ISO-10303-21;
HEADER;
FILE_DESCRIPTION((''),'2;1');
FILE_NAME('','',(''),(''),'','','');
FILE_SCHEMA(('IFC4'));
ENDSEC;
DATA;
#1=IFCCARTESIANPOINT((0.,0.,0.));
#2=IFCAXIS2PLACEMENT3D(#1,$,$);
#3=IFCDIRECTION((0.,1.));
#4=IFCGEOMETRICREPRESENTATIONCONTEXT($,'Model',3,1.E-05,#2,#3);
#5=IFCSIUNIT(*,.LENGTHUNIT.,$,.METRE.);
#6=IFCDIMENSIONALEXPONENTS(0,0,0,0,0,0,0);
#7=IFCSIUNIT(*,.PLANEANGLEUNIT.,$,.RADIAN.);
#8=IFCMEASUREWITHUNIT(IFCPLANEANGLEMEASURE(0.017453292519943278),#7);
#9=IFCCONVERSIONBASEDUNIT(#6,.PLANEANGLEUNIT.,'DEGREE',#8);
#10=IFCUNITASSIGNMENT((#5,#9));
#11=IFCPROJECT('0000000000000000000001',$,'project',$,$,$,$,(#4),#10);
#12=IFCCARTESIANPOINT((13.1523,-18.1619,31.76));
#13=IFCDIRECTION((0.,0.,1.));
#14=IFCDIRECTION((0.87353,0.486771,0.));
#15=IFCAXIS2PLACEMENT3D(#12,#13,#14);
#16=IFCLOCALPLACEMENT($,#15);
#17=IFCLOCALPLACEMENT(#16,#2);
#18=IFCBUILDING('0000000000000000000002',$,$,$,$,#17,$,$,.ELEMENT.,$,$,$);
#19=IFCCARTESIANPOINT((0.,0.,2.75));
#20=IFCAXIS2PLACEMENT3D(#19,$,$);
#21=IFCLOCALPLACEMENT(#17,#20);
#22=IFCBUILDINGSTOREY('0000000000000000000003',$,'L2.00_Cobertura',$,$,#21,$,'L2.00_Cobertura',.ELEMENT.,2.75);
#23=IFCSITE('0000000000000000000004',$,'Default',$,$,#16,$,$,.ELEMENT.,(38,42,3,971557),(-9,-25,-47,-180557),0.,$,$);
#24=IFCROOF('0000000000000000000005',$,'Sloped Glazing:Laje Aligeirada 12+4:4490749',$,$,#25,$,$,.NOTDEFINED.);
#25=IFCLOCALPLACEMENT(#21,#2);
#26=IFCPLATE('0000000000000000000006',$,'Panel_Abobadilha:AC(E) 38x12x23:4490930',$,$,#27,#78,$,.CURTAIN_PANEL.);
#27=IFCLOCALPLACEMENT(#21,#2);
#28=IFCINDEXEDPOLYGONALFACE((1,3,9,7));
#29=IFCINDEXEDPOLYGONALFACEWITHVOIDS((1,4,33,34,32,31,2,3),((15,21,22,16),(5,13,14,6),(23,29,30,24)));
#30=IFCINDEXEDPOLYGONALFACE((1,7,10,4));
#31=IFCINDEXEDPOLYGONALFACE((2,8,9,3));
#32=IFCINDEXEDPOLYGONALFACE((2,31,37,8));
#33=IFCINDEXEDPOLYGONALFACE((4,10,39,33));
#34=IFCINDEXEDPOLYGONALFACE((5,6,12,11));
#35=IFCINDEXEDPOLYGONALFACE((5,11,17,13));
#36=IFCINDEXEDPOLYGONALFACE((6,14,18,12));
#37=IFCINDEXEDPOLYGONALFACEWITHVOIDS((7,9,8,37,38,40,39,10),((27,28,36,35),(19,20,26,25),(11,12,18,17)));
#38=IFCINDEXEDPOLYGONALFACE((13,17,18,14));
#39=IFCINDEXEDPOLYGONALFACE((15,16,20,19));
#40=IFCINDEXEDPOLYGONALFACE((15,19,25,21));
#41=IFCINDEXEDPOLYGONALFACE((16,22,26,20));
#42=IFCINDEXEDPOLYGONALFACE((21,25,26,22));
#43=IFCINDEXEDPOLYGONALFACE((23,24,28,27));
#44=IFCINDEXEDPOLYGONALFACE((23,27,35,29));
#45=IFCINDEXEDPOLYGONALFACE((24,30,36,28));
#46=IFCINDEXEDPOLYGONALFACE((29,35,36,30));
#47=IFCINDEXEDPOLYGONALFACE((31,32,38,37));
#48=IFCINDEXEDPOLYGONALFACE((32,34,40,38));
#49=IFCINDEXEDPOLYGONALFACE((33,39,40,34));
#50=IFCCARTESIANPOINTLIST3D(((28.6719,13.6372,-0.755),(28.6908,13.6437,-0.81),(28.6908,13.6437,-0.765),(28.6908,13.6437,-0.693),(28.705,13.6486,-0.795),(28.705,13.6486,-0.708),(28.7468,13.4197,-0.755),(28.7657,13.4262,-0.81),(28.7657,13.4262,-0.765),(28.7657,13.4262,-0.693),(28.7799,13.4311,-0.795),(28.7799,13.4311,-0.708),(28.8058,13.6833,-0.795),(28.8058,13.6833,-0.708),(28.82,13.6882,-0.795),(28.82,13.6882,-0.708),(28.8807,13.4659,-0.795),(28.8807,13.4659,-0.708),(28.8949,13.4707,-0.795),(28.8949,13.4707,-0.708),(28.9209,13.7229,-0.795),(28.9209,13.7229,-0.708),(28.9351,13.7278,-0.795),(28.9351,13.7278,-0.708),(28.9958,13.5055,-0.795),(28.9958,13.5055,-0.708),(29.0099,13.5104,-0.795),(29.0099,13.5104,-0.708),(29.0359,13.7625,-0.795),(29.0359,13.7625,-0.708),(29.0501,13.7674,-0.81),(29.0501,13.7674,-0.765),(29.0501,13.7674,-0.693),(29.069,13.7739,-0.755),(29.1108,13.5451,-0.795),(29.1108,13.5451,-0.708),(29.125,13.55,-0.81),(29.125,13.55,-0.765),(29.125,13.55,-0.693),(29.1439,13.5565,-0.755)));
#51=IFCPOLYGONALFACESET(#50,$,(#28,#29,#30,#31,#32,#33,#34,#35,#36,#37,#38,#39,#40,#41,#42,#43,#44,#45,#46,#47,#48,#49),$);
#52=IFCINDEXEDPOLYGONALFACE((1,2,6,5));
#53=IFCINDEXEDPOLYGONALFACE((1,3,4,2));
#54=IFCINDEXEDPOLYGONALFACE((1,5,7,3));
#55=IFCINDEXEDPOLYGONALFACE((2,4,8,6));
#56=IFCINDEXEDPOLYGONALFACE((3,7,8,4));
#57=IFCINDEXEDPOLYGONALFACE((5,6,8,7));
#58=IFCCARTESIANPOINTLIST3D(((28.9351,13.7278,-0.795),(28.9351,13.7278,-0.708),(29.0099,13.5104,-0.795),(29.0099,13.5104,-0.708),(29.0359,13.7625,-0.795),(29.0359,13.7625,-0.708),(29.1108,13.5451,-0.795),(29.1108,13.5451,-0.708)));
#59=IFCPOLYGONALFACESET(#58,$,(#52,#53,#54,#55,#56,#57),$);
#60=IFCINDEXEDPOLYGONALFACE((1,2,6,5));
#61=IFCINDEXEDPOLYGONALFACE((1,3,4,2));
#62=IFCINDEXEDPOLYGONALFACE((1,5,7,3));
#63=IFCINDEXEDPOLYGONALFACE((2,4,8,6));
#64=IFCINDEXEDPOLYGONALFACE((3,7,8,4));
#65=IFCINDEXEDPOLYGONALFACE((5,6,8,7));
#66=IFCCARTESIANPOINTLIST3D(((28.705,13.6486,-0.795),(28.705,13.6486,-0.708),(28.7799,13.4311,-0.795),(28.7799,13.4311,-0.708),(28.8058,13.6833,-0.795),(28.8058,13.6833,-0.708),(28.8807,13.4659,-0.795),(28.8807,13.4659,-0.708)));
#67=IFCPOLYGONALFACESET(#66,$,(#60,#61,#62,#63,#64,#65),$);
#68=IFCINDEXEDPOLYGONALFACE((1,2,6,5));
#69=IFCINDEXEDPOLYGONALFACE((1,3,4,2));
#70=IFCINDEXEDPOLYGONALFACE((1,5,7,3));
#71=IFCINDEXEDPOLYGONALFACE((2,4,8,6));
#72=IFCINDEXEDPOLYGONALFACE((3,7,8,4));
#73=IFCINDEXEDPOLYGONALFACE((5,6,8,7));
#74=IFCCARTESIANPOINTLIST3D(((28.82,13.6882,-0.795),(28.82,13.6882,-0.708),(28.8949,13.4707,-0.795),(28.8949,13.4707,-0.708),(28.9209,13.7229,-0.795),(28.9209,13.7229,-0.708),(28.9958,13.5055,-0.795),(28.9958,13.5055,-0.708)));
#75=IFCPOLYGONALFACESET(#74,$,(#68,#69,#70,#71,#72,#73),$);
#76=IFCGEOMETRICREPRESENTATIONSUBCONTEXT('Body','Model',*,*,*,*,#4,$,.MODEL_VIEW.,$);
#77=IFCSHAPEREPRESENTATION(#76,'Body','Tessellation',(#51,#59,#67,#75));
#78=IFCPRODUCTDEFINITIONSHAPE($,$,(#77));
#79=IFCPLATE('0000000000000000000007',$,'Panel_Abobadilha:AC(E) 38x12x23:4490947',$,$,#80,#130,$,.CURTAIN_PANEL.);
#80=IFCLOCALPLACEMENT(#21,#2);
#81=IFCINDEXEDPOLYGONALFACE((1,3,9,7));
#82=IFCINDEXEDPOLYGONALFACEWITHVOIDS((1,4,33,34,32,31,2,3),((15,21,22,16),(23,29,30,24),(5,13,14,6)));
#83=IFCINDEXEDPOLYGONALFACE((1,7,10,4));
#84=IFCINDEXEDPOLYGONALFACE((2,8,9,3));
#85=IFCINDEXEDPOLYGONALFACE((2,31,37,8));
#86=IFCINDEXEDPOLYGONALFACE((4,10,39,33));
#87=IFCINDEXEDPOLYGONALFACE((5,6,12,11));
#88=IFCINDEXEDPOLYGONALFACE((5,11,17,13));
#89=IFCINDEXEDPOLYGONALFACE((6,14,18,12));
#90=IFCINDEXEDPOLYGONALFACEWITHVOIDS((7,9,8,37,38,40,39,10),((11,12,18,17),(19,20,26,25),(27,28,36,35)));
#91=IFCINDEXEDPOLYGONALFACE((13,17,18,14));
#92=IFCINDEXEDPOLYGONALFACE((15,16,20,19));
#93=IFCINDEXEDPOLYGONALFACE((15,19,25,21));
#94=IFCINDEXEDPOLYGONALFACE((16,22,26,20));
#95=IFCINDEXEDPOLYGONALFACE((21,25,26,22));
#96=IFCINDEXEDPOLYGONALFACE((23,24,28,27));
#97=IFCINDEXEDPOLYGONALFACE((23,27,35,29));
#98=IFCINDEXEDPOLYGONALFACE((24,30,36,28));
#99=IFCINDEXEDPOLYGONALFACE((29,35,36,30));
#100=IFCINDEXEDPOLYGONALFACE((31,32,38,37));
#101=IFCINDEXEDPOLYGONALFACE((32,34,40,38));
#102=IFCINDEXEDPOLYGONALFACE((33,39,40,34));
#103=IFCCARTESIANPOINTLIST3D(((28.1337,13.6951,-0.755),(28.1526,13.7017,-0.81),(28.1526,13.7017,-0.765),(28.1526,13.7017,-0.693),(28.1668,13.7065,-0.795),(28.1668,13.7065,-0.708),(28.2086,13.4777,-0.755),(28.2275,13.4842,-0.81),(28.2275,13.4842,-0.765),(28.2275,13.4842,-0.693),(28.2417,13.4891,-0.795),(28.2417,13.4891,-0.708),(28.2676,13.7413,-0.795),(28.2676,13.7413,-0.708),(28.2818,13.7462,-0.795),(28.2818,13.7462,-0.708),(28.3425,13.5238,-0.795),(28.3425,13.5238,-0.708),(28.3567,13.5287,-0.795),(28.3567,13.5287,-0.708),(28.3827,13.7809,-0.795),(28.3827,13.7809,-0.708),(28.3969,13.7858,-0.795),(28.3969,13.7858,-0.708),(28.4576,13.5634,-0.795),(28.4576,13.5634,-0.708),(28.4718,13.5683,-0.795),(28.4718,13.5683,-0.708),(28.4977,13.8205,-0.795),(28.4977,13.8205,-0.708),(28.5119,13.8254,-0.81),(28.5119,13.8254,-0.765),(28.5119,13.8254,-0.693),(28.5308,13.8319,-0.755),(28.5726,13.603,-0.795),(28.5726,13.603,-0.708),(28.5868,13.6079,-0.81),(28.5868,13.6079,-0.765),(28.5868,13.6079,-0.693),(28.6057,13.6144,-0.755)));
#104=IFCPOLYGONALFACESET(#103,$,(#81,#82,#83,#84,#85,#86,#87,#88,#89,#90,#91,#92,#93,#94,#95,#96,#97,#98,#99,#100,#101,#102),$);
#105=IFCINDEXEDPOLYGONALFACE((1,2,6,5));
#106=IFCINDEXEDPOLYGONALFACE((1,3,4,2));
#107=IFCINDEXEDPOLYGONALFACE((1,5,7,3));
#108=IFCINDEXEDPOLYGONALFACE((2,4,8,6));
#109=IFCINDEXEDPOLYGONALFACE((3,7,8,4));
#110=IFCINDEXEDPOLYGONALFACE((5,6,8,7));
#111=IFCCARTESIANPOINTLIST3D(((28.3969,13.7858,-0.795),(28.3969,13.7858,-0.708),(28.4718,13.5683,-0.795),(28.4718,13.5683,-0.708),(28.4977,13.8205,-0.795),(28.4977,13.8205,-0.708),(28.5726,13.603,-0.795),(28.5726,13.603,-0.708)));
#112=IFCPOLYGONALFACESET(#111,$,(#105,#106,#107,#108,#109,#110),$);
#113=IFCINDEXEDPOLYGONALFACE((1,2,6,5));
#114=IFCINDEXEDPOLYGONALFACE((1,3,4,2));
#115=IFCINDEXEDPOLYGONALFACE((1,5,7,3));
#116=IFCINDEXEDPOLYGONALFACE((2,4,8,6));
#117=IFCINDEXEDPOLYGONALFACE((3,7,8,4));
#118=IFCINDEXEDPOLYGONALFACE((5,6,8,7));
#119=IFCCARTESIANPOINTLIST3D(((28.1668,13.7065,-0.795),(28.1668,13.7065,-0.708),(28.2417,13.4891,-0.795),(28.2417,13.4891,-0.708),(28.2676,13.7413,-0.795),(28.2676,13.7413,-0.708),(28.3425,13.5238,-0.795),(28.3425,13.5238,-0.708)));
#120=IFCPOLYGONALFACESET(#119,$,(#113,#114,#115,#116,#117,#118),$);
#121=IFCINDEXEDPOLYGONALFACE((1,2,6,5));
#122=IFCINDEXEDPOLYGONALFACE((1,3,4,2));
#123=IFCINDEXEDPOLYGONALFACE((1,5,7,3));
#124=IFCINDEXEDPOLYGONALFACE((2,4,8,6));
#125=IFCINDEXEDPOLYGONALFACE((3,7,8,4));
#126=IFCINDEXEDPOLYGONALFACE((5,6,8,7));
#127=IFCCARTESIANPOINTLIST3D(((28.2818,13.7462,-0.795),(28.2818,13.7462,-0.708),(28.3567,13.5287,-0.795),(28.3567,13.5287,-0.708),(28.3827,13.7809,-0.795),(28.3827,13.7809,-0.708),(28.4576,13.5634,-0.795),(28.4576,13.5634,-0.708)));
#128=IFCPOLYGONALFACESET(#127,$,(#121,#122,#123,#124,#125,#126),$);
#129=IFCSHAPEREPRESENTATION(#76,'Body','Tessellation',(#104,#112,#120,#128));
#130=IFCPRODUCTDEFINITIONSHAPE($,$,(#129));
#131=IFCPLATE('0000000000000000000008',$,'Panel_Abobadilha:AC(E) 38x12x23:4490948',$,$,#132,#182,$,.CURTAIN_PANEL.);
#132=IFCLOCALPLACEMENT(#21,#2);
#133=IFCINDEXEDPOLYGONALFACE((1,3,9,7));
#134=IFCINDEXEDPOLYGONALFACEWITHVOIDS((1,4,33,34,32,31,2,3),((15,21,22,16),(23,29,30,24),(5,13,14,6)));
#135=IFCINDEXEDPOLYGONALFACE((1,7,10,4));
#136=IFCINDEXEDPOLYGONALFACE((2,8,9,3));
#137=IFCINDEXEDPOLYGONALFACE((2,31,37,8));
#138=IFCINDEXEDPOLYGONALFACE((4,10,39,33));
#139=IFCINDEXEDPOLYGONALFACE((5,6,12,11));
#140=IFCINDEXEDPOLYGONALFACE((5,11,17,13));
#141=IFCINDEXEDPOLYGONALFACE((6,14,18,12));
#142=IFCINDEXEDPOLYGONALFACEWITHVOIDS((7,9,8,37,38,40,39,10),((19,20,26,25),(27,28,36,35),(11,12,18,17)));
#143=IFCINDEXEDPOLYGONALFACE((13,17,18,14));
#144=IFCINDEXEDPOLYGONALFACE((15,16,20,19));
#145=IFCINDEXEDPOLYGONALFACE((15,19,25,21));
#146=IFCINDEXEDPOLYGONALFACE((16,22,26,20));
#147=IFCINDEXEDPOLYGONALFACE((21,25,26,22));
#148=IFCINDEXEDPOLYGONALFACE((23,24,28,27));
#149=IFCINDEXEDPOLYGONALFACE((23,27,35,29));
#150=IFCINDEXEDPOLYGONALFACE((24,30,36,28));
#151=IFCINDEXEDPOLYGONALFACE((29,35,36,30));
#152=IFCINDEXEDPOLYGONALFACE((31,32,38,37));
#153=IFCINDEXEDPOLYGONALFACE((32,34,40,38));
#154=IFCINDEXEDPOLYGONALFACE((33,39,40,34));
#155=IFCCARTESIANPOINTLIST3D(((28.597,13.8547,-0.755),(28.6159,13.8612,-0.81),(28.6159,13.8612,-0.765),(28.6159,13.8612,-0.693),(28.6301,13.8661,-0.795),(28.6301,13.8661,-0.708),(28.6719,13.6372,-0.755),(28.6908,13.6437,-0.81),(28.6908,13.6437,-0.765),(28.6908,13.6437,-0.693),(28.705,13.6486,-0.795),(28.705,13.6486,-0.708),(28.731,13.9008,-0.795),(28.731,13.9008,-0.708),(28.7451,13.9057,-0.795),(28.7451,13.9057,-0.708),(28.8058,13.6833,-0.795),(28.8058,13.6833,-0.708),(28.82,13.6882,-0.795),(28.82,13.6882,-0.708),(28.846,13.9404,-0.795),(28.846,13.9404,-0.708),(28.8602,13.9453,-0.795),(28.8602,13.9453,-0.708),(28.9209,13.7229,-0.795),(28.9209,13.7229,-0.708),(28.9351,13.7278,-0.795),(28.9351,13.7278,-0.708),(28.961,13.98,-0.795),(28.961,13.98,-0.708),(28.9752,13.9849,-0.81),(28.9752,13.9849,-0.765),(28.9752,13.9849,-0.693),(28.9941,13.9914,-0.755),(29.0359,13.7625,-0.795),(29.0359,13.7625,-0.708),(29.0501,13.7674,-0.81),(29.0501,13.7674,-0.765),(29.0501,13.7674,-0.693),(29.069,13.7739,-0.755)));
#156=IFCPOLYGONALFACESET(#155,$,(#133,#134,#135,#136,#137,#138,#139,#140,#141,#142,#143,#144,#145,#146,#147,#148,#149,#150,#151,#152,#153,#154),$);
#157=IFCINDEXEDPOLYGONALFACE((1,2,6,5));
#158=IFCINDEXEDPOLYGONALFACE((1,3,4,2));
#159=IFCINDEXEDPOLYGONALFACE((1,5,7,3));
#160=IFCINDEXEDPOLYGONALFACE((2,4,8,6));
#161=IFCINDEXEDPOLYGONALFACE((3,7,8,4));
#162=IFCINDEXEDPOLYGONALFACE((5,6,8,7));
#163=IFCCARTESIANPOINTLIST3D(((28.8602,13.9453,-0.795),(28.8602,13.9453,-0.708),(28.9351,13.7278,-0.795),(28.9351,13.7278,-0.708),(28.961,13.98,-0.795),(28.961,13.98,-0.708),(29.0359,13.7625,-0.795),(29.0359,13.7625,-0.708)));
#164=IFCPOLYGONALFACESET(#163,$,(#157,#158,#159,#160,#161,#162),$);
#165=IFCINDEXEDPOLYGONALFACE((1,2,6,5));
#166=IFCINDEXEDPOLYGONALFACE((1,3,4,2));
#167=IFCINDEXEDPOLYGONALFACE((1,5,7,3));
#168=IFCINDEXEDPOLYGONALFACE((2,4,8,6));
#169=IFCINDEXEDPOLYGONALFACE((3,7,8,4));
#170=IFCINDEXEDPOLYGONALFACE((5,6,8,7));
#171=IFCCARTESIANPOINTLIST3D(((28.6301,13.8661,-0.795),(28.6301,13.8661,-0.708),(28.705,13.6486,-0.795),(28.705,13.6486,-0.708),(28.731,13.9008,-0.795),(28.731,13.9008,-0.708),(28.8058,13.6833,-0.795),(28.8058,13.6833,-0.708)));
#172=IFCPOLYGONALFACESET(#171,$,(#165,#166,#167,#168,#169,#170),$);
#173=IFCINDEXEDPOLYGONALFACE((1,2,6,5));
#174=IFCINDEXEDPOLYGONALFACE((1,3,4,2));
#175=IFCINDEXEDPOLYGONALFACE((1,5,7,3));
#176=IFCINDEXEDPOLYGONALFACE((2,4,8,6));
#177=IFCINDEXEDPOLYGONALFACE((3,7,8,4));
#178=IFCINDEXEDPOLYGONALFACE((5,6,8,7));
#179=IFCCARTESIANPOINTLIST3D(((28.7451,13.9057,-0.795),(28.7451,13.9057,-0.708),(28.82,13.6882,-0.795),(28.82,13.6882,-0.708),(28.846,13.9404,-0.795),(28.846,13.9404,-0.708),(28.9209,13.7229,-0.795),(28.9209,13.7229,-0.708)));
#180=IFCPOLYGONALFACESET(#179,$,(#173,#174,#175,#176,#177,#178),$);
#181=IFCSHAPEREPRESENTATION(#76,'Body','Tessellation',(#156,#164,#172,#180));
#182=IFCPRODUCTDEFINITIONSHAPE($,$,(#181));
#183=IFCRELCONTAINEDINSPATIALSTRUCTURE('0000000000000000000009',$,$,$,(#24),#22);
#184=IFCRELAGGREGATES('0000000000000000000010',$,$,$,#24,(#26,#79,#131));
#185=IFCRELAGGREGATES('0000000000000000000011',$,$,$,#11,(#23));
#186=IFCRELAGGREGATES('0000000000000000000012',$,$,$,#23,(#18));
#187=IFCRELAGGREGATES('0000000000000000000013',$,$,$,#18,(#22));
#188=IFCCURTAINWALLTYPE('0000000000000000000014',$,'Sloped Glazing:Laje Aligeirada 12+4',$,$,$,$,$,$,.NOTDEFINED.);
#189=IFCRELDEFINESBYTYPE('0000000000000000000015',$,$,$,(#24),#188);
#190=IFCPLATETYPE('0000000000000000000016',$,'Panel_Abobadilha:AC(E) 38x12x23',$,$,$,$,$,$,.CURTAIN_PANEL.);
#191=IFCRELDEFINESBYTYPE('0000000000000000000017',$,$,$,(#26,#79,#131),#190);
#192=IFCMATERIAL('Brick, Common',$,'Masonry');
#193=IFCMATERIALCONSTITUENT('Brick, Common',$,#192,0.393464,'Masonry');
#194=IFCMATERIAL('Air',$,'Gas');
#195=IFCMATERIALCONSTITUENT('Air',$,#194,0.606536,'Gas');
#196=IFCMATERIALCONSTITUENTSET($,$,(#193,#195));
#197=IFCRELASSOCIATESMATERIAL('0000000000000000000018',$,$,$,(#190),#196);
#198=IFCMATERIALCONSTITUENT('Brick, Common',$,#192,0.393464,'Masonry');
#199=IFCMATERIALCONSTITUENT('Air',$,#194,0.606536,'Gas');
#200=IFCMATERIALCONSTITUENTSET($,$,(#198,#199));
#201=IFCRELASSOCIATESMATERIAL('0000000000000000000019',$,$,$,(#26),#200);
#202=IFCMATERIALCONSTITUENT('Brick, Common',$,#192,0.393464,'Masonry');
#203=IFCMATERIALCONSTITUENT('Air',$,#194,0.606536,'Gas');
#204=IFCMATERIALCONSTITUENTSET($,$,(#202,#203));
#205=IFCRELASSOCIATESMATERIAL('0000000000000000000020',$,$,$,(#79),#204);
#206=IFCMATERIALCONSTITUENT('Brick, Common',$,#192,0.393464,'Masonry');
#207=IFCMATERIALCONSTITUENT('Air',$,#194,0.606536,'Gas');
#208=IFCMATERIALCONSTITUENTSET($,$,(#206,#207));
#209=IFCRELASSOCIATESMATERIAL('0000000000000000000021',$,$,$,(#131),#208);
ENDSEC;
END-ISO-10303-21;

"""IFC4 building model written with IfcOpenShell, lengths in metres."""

from ifc_helpers import new_model, entity, si_unit, converted_unit, direction, frame, origin, place, context, subcontext, project, spatial, indexed_curve, outline, extrude, source, transform, mapped, material, constituent, constituent_set, type_object, type_shapes, element, aggregate, save


model = new_model("IFC4")

# Units and contexts
model_context = context("Model", 3, precision=1e-05, world=origin(), true_north=direction((0.0, 1.0)))
body_context = subcontext(model_context, "Body", "Model", "MODEL_VIEW")
ifc_project = project(units=[si_unit("LENGTHUNIT", "METRE"), converted_unit("PLANEANGLEUNIT", "DEGREE", entity("IfcPlaneAngleMeasure", 0.017453292519943278), si_unit("PLANEANGLEUNIT", "RADIAN"), dimensions=[0, 0, 0, 0, 0, 0, 0])], contexts=[model_context])

# Site, building, storey
site_placement = place(None, frame((13.1523, -18.1619, 31.76), z_axis=(0.0, 0.0, 1.0), x_axis=(0.87353, 0.486771, 0.0)))
site = spatial("IfcSite", under=ifc_project, at=site_placement, Name="Default", CompositionType="ELEMENT", RefLatitude=(38, 42, 3, 971557), RefLongitude=(-9, -25, -47, -180557), RefElevation=0.0)
building_placement = place(site_placement, origin())
building = spatial("IfcBuilding", under=site, at=building_placement, CompositionType="ELEMENT")
storey_placement = place(building_placement, frame((0.0, 0.0, 2.75)))
storey = spatial("IfcBuildingStorey", under=building, at=storey_placement, Name="L2.00_Cobertura", LongName="L2.00_Cobertura", CompositionType="ELEMENT", Elevation=2.75)

# Roof, plates
curtain_wall_type = type_object("IfcCurtainWallType", Name="Sloped Glazing:Laje Aligeirada 12+4", PredefinedType="NOTDEFINED")
roof_placement = place(storey_placement, frame((0.0, 0.0, -2.75)))
roof = element("IfcRoof", 1, at=roof_placement, inside=storey, type_object=curtain_wall_type, Name="Sloped Glazing:Laje Aligeirada 12+4:4490749", PredefinedType="NOTDEFINED")
ifc_material_1 = material(Name="Brick, Common", Category="Masonry")
ifc_material_2 = material(Name="Air", Category="Gas")
ifc_constituent_1 = constituent(ifc_material_1, Name="Brick, Common", Category="Masonry", fraction=0.393464)
ifc_constituent_2 = constituent(ifc_material_2, Name="Air", Category="Gas", fraction=0.606536)
ifc_constituent_set_1 = constituent_set(constituents=[ifc_constituent_1, ifc_constituent_2])
plate_type_1 = type_object("IfcPlateType", Name="Panel_Abobadilha:AC(E) 38x12x23", PredefinedType="CURTAIN_PANEL", material=ifc_constituent_set_1)
shared_shape_1 = source(origin(), body_context, "Body", "SweptSolid", [
    extrude(outline(indexed_curve([(-0.19, -0.0543), (0.19, -0.0543), (0.19, -0.0093), (0.21, 0.0007), (0.19, 0.0628), (-0.19, 0.0628), (-0.21, 0.0007), (-0.19, -0.0093), (-0.19, -0.0543)], self_intersect=False), holes=[indexed_curve([(-0.0683, 0.0477), (-0.0683, -0.0393), (-0.175, -0.0393), (-0.175, 0.0477), (-0.0683, 0.0477)], self_intersect=False), indexed_curve([(0.0533, 0.0477), (0.0533, -0.0393), (-0.0533, -0.0393), (-0.0533, 0.0477), (0.0533, 0.0477)], self_intersect=False), indexed_curve([(0.175, 0.0477), (0.175, -0.0393), (0.0683, -0.0393), (0.0683, 0.0477), (0.175, 0.0477)], self_intersect=False)]), frame((0.0, 0.0543, 0.0)), (0.0, 0.0, 1.0), 0.23),
    extrude(outline(indexed_curve([(-0.0533, -0.0435), (0.0533, -0.0435), (0.0533, 0.0435), (-0.0533, 0.0435), (-0.0533, -0.0435)], self_intersect=False)), frame((0.1217, 0.0585, 0.0), z_axis=(0.0, 0.0, 1.0), x_axis=(-1.0, 0.0, 0.0)), (0.0, 0.0, 1.0), 0.23),
    extrude(outline(indexed_curve([(-0.0533, -0.0435), (0.0533, -0.0435), (0.0533, 0.0435), (-0.0533, 0.0435), (-0.0533, -0.0435)], self_intersect=False)), frame((-0.1217, 0.0585, 0.0), z_axis=(0.0, 0.0, 1.0), x_axis=(-1.0, 0.0, 0.0)), (0.0, 0.0, 1.0), 0.23),
    extrude(outline(indexed_curve([(-0.0533, -0.0435), (0.0533, -0.0435), (0.0533, 0.0435), (-0.0533, 0.0435), (-0.0533, -0.0435)], self_intersect=False)), frame((0.0, 0.0585, 0.0), z_axis=(0.0, 0.0, 1.0), x_axis=(-1.0, 0.0, 0.0)), (0.0, 0.0, 1.0), 0.23),
])
type_shapes(plate_type_1, [shared_shape_1])
ifc_constituent_3 = constituent(ifc_material_1, Name="Brick, Common", Category="Masonry", fraction=0.393464)
ifc_constituent_4 = constituent(ifc_material_2, Name="Air", Category="Gas", fraction=0.606536)
ifc_constituent_set_2 = constituent_set(constituents=[ifc_constituent_3, ifc_constituent_4])
plate_1_placement = place(roof_placement, frame((28.8704, 13.7056, 1.94), z_axis=(0.325568, -0.945519, 0.0), x_axis=(0.945519, 0.325568, 0.0)))
plate_1 = element("IfcPlate", 2, at=plate_1_placement, type_object=plate_type_1, material=ifc_constituent_set_2, Name="Panel_Abobadilha:AC(E) 38x12x23:4490930", PredefinedType="CURTAIN_PANEL", context=body_context, shape_type="MappedRepresentation", body=[
    mapped(shared_shape_1, transform((0.0, 0.0, 0.0), scale=1.0)),
])
ifc_constituent_5 = constituent(ifc_material_1, Name="Brick, Common", Category="Masonry", fraction=0.393464)
ifc_constituent_6 = constituent(ifc_material_2, Name="Air", Category="Gas", fraction=0.606536)
ifc_constituent_set_3 = constituent_set(constituents=[ifc_constituent_5, ifc_constituent_6])
plate_2_placement = place(roof_placement, frame((28.3323, 13.7635, 1.94), z_axis=(0.325568, -0.945519, 0.0), x_axis=(0.945519, 0.325568, 0.0)))
plate_2 = element("IfcPlate", 3, at=plate_2_placement, type_object=plate_type_1, material=ifc_constituent_set_3, Name="Panel_Abobadilha:AC(E) 38x12x23:4490947", PredefinedType="CURTAIN_PANEL", context=body_context, shape_type="MappedRepresentation", body=[
    mapped(shared_shape_1, transform((0.0, 0.0, 0.0), scale=1.0)),
])
ifc_constituent_7 = constituent(ifc_material_1, Name="Brick, Common", Category="Masonry", fraction=0.393464)
ifc_constituent_8 = constituent(ifc_material_2, Name="Air", Category="Gas", fraction=0.606536)
ifc_constituent_set_4 = constituent_set(constituents=[ifc_constituent_7, ifc_constituent_8])
plate_3_placement = place(roof_placement, frame((28.7956, 13.923, 1.94), z_axis=(0.325568, -0.945519, 0.0), x_axis=(0.945519, 0.325568, 0.0)))
plate_3 = element("IfcPlate", 4, at=plate_3_placement, type_object=plate_type_1, material=ifc_constituent_set_4, Name="Panel_Abobadilha:AC(E) 38x12x23:4490948", PredefinedType="CURTAIN_PANEL", context=body_context, shape_type="MappedRepresentation", body=[
    mapped(shared_shape_1, transform((0.0, 0.0, 0.0), scale=1.0)),
])
aggregate(roof, [plate_1, plate_2, plate_3])

save(model, "model.ifc")
